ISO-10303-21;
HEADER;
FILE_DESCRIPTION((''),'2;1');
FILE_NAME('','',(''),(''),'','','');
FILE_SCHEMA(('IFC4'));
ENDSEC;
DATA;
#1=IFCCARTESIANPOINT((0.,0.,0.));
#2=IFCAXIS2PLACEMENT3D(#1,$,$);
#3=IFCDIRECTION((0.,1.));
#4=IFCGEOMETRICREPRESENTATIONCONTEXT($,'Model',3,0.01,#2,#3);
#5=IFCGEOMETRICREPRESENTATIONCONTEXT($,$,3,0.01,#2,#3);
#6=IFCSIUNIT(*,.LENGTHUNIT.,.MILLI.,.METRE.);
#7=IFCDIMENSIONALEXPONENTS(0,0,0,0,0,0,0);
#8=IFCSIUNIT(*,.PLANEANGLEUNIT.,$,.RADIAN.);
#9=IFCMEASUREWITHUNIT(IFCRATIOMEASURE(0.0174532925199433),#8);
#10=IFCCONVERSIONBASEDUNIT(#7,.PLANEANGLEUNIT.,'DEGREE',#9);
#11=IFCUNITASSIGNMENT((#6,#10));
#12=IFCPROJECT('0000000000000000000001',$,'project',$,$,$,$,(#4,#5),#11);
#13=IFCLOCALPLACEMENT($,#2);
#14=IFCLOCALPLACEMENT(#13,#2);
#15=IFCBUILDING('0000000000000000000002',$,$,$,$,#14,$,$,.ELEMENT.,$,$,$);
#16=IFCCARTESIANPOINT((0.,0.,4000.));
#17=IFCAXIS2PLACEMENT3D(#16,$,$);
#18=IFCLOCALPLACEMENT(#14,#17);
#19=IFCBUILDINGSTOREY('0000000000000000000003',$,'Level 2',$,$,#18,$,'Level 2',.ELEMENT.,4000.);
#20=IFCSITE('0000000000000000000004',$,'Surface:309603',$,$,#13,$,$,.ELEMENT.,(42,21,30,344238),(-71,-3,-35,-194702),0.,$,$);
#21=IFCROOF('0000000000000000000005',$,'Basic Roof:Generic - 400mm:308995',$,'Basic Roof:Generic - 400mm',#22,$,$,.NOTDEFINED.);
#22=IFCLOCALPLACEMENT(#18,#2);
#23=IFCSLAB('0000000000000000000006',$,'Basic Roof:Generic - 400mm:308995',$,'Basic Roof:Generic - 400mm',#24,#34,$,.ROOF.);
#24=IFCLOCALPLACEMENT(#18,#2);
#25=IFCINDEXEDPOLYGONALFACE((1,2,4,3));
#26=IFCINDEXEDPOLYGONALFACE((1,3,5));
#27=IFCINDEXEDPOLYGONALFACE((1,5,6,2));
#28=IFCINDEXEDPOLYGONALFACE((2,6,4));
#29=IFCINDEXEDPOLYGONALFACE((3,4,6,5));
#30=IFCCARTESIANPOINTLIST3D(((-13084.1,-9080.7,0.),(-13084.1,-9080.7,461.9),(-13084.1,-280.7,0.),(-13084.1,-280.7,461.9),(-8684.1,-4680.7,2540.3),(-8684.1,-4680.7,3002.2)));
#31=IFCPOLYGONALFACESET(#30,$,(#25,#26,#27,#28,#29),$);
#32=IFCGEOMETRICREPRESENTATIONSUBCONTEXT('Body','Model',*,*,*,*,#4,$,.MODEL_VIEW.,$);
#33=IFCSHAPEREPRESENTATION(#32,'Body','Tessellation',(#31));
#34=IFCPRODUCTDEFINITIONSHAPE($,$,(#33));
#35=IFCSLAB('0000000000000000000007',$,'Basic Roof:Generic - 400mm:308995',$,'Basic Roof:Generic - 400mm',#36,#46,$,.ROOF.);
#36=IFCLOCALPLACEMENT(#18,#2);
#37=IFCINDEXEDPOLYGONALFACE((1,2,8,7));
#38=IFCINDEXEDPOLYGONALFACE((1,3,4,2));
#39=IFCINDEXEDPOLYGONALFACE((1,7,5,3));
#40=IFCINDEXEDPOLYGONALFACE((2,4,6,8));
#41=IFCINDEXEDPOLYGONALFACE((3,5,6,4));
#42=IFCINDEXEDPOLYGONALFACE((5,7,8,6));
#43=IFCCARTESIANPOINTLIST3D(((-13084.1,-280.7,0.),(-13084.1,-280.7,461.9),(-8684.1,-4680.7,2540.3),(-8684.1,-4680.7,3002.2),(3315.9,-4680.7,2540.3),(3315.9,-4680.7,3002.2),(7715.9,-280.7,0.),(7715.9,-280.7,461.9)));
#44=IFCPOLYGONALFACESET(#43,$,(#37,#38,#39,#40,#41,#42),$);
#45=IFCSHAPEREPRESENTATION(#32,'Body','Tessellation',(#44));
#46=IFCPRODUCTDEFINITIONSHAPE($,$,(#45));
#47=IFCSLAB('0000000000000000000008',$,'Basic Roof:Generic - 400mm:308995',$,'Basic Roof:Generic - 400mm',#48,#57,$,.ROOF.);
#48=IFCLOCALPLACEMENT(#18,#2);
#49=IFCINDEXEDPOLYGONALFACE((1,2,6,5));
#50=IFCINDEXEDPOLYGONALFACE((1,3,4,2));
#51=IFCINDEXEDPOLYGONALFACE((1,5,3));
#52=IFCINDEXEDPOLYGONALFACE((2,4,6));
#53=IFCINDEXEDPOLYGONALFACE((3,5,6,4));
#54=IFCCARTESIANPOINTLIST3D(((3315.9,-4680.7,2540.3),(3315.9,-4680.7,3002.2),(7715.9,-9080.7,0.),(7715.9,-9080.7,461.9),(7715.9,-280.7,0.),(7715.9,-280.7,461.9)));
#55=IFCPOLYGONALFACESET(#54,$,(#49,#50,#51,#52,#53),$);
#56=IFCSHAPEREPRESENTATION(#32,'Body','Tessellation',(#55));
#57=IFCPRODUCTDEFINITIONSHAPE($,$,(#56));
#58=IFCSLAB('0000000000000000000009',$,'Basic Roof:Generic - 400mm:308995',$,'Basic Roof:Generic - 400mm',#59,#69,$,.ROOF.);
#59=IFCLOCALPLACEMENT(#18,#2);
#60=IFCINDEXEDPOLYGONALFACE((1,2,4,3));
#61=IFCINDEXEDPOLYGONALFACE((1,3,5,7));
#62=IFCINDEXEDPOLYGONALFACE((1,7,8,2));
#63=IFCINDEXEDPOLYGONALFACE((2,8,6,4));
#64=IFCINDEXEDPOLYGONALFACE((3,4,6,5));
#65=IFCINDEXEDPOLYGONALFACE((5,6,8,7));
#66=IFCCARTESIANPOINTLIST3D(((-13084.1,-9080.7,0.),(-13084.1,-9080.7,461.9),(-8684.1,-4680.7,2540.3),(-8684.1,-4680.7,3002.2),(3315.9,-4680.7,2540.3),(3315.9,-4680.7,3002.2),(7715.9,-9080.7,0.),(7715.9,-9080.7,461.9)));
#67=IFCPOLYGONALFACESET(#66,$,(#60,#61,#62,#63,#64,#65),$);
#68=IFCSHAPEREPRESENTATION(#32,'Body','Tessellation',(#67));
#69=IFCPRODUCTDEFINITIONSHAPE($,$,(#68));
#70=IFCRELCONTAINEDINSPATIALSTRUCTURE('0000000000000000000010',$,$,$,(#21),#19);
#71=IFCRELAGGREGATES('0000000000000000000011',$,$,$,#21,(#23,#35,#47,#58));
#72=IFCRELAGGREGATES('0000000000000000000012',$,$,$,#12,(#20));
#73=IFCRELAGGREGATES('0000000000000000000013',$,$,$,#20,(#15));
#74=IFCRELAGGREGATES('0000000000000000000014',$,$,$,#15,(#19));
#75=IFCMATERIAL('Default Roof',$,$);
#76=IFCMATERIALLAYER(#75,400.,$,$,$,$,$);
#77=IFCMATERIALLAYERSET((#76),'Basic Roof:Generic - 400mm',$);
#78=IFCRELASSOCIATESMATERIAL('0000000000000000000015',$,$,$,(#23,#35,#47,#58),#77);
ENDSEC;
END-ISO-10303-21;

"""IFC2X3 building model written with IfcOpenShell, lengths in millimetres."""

from ifc_helpers import new_model, entity, si_unit, converted_unit, direction, frame, origin, place, context, subcontext, project, spatial, polyline, outline, extrude, material, layer, layer_set, element, aggregate, save


model = new_model("IFC2X3")

# Units and contexts
model_context = context("Model", 3, precision=0.01, world=origin(), true_north=direction((0.0, 1.0)))
context_of_model = context(None, 3, precision=0.01, world=origin(), true_north=direction((0.0, 1.0)))
body_context = subcontext(model_context, "Body", "Model", "MODEL_VIEW")
ifc_project = project(units=[si_unit("LENGTHUNIT", "METRE", prefix="MILLI"), converted_unit("PLANEANGLEUNIT", "DEGREE", entity("IfcRatioMeasure", 0.0174532925199433), si_unit("PLANEANGLEUNIT", "RADIAN"), dimensions=[0, 0, 0, 0, 0, 0, 0])], contexts=[model_context, context_of_model])

# Site, building, storey
site_placement = place(None, origin())
site = spatial("IfcSite", under=ifc_project, at=site_placement, Name="Surface:309603", CompositionType="ELEMENT", RefLatitude=(42, 21, 30, 344238), RefLongitude=(-71, -3, -35, -194702), RefElevation=0.0)
building_placement = place(site_placement, origin())
building = spatial("IfcBuilding", under=site, at=building_placement, CompositionType="ELEMENT")
storey_placement = place(building_placement, frame((0.0, 0.0, 4000.0)))
storey = spatial("IfcBuildingStorey", under=building, at=storey_placement, Name="Level 2", LongName="Level 2", CompositionType="ELEMENT", Elevation=4000.0)

# Roof, slabs
roof_placement = place(storey_placement, frame((-13084.1, -9080.7, 0.0)))
roof = element("IfcRoof", 1, at=roof_placement, inside=storey, Name="Basic Roof:Generic - 400mm:308995", ObjectType="Basic Roof:Generic - 400mm", ShapeType="NOTDEFINED")
ifc_material = material(Name="Default Roof")
ifc_layer = layer(ifc_material, 400.0)
ifc_layer_set = layer_set([ifc_layer], Name="Basic Roof:Generic - 400mm")
slab_1_placement = place(roof_placement, origin())
slab_1 = element("IfcSlab", 2, at=slab_1_placement, material=ifc_layer_set, Name="Basic Roof:Generic - 400mm:308995", ObjectType="Basic Roof:Generic - 400mm", PredefinedType="ROOF", context=body_context, shape_type="SweptSolid", body=[
    extrude(outline(polyline([(2540.3, 0.0), (-2540.3, 4400.0), (-2540.3, -4400.0), (2540.3, 0.0)])), frame((2200.0, 4400.0, 1270.2), z_axis=(-0.5, 0.0, 0.866025), x_axis=(0.866025, 0.0, 0.5)), (0.5, 0.0, 0.866025), 461.9),
])
slab_2_placement = place(roof_placement, origin())
slab_2 = element("IfcSlab", 3, at=slab_2_placement, material=ifc_layer_set, Name="Basic Roof:Generic - 400mm:308995", ObjectType="Basic Roof:Generic - 400mm", PredefinedType="ROOF", context=body_context, shape_type="SweptSolid", body=[
    extrude(outline(polyline([(10400.0, 2540.3), (-10400.0, 2540.3), (-6000.0, -2540.3), (6000.0, -2540.3), (10400.0, 2540.3)])), frame((10400.0, 6600.0, 1270.2), z_axis=(0.0, 0.5, 0.866025), x_axis=(1.0, 0.0, 0.0)), (0.0, -0.5, 0.866025), 461.9),
])
slab_3_placement = place(roof_placement, origin())
slab_3 = element("IfcSlab", 4, at=slab_3_placement, material=ifc_layer_set, Name="Basic Roof:Generic - 400mm:308995", ObjectType="Basic Roof:Generic - 400mm", PredefinedType="ROOF", context=body_context, shape_type="SweptSolid", body=[
    extrude(outline(polyline([(2540.3, -4400.0), (2540.3, 4400.0), (-2540.3, 0.0), (2540.3, -4400.0)])), frame((18600.0, 4400.0, 1270.2), z_axis=(0.5, 0.0, 0.866025), x_axis=(0.866025, 0.0, -0.5)), (-0.5, 0.0, 0.866025), 461.9),
])
slab_4_placement = place(roof_placement, origin())
slab_4 = element("IfcSlab", 5, at=slab_4_placement, material=ifc_layer_set, Name="Basic Roof:Generic - 400mm:308995", ObjectType="Basic Roof:Generic - 400mm", PredefinedType="ROOF", context=body_context, shape_type="SweptSolid", body=[
    extrude(outline(polyline([(-10400.0, -2540.3), (10400.0, -2540.3), (6000.0, 2540.3), (-6000.0, 2540.3), (-10400.0, -2540.3)])), frame((10400.0, 2200.0, 1270.2), z_axis=(0.0, -0.5, 0.866025), x_axis=(1.0, 0.0, 0.0)), (0.0, 0.5, 0.866025), 461.9),
])
aggregate(roof, [slab_1, slab_2, slab_3, slab_4])

save(model, "model.ifc")
